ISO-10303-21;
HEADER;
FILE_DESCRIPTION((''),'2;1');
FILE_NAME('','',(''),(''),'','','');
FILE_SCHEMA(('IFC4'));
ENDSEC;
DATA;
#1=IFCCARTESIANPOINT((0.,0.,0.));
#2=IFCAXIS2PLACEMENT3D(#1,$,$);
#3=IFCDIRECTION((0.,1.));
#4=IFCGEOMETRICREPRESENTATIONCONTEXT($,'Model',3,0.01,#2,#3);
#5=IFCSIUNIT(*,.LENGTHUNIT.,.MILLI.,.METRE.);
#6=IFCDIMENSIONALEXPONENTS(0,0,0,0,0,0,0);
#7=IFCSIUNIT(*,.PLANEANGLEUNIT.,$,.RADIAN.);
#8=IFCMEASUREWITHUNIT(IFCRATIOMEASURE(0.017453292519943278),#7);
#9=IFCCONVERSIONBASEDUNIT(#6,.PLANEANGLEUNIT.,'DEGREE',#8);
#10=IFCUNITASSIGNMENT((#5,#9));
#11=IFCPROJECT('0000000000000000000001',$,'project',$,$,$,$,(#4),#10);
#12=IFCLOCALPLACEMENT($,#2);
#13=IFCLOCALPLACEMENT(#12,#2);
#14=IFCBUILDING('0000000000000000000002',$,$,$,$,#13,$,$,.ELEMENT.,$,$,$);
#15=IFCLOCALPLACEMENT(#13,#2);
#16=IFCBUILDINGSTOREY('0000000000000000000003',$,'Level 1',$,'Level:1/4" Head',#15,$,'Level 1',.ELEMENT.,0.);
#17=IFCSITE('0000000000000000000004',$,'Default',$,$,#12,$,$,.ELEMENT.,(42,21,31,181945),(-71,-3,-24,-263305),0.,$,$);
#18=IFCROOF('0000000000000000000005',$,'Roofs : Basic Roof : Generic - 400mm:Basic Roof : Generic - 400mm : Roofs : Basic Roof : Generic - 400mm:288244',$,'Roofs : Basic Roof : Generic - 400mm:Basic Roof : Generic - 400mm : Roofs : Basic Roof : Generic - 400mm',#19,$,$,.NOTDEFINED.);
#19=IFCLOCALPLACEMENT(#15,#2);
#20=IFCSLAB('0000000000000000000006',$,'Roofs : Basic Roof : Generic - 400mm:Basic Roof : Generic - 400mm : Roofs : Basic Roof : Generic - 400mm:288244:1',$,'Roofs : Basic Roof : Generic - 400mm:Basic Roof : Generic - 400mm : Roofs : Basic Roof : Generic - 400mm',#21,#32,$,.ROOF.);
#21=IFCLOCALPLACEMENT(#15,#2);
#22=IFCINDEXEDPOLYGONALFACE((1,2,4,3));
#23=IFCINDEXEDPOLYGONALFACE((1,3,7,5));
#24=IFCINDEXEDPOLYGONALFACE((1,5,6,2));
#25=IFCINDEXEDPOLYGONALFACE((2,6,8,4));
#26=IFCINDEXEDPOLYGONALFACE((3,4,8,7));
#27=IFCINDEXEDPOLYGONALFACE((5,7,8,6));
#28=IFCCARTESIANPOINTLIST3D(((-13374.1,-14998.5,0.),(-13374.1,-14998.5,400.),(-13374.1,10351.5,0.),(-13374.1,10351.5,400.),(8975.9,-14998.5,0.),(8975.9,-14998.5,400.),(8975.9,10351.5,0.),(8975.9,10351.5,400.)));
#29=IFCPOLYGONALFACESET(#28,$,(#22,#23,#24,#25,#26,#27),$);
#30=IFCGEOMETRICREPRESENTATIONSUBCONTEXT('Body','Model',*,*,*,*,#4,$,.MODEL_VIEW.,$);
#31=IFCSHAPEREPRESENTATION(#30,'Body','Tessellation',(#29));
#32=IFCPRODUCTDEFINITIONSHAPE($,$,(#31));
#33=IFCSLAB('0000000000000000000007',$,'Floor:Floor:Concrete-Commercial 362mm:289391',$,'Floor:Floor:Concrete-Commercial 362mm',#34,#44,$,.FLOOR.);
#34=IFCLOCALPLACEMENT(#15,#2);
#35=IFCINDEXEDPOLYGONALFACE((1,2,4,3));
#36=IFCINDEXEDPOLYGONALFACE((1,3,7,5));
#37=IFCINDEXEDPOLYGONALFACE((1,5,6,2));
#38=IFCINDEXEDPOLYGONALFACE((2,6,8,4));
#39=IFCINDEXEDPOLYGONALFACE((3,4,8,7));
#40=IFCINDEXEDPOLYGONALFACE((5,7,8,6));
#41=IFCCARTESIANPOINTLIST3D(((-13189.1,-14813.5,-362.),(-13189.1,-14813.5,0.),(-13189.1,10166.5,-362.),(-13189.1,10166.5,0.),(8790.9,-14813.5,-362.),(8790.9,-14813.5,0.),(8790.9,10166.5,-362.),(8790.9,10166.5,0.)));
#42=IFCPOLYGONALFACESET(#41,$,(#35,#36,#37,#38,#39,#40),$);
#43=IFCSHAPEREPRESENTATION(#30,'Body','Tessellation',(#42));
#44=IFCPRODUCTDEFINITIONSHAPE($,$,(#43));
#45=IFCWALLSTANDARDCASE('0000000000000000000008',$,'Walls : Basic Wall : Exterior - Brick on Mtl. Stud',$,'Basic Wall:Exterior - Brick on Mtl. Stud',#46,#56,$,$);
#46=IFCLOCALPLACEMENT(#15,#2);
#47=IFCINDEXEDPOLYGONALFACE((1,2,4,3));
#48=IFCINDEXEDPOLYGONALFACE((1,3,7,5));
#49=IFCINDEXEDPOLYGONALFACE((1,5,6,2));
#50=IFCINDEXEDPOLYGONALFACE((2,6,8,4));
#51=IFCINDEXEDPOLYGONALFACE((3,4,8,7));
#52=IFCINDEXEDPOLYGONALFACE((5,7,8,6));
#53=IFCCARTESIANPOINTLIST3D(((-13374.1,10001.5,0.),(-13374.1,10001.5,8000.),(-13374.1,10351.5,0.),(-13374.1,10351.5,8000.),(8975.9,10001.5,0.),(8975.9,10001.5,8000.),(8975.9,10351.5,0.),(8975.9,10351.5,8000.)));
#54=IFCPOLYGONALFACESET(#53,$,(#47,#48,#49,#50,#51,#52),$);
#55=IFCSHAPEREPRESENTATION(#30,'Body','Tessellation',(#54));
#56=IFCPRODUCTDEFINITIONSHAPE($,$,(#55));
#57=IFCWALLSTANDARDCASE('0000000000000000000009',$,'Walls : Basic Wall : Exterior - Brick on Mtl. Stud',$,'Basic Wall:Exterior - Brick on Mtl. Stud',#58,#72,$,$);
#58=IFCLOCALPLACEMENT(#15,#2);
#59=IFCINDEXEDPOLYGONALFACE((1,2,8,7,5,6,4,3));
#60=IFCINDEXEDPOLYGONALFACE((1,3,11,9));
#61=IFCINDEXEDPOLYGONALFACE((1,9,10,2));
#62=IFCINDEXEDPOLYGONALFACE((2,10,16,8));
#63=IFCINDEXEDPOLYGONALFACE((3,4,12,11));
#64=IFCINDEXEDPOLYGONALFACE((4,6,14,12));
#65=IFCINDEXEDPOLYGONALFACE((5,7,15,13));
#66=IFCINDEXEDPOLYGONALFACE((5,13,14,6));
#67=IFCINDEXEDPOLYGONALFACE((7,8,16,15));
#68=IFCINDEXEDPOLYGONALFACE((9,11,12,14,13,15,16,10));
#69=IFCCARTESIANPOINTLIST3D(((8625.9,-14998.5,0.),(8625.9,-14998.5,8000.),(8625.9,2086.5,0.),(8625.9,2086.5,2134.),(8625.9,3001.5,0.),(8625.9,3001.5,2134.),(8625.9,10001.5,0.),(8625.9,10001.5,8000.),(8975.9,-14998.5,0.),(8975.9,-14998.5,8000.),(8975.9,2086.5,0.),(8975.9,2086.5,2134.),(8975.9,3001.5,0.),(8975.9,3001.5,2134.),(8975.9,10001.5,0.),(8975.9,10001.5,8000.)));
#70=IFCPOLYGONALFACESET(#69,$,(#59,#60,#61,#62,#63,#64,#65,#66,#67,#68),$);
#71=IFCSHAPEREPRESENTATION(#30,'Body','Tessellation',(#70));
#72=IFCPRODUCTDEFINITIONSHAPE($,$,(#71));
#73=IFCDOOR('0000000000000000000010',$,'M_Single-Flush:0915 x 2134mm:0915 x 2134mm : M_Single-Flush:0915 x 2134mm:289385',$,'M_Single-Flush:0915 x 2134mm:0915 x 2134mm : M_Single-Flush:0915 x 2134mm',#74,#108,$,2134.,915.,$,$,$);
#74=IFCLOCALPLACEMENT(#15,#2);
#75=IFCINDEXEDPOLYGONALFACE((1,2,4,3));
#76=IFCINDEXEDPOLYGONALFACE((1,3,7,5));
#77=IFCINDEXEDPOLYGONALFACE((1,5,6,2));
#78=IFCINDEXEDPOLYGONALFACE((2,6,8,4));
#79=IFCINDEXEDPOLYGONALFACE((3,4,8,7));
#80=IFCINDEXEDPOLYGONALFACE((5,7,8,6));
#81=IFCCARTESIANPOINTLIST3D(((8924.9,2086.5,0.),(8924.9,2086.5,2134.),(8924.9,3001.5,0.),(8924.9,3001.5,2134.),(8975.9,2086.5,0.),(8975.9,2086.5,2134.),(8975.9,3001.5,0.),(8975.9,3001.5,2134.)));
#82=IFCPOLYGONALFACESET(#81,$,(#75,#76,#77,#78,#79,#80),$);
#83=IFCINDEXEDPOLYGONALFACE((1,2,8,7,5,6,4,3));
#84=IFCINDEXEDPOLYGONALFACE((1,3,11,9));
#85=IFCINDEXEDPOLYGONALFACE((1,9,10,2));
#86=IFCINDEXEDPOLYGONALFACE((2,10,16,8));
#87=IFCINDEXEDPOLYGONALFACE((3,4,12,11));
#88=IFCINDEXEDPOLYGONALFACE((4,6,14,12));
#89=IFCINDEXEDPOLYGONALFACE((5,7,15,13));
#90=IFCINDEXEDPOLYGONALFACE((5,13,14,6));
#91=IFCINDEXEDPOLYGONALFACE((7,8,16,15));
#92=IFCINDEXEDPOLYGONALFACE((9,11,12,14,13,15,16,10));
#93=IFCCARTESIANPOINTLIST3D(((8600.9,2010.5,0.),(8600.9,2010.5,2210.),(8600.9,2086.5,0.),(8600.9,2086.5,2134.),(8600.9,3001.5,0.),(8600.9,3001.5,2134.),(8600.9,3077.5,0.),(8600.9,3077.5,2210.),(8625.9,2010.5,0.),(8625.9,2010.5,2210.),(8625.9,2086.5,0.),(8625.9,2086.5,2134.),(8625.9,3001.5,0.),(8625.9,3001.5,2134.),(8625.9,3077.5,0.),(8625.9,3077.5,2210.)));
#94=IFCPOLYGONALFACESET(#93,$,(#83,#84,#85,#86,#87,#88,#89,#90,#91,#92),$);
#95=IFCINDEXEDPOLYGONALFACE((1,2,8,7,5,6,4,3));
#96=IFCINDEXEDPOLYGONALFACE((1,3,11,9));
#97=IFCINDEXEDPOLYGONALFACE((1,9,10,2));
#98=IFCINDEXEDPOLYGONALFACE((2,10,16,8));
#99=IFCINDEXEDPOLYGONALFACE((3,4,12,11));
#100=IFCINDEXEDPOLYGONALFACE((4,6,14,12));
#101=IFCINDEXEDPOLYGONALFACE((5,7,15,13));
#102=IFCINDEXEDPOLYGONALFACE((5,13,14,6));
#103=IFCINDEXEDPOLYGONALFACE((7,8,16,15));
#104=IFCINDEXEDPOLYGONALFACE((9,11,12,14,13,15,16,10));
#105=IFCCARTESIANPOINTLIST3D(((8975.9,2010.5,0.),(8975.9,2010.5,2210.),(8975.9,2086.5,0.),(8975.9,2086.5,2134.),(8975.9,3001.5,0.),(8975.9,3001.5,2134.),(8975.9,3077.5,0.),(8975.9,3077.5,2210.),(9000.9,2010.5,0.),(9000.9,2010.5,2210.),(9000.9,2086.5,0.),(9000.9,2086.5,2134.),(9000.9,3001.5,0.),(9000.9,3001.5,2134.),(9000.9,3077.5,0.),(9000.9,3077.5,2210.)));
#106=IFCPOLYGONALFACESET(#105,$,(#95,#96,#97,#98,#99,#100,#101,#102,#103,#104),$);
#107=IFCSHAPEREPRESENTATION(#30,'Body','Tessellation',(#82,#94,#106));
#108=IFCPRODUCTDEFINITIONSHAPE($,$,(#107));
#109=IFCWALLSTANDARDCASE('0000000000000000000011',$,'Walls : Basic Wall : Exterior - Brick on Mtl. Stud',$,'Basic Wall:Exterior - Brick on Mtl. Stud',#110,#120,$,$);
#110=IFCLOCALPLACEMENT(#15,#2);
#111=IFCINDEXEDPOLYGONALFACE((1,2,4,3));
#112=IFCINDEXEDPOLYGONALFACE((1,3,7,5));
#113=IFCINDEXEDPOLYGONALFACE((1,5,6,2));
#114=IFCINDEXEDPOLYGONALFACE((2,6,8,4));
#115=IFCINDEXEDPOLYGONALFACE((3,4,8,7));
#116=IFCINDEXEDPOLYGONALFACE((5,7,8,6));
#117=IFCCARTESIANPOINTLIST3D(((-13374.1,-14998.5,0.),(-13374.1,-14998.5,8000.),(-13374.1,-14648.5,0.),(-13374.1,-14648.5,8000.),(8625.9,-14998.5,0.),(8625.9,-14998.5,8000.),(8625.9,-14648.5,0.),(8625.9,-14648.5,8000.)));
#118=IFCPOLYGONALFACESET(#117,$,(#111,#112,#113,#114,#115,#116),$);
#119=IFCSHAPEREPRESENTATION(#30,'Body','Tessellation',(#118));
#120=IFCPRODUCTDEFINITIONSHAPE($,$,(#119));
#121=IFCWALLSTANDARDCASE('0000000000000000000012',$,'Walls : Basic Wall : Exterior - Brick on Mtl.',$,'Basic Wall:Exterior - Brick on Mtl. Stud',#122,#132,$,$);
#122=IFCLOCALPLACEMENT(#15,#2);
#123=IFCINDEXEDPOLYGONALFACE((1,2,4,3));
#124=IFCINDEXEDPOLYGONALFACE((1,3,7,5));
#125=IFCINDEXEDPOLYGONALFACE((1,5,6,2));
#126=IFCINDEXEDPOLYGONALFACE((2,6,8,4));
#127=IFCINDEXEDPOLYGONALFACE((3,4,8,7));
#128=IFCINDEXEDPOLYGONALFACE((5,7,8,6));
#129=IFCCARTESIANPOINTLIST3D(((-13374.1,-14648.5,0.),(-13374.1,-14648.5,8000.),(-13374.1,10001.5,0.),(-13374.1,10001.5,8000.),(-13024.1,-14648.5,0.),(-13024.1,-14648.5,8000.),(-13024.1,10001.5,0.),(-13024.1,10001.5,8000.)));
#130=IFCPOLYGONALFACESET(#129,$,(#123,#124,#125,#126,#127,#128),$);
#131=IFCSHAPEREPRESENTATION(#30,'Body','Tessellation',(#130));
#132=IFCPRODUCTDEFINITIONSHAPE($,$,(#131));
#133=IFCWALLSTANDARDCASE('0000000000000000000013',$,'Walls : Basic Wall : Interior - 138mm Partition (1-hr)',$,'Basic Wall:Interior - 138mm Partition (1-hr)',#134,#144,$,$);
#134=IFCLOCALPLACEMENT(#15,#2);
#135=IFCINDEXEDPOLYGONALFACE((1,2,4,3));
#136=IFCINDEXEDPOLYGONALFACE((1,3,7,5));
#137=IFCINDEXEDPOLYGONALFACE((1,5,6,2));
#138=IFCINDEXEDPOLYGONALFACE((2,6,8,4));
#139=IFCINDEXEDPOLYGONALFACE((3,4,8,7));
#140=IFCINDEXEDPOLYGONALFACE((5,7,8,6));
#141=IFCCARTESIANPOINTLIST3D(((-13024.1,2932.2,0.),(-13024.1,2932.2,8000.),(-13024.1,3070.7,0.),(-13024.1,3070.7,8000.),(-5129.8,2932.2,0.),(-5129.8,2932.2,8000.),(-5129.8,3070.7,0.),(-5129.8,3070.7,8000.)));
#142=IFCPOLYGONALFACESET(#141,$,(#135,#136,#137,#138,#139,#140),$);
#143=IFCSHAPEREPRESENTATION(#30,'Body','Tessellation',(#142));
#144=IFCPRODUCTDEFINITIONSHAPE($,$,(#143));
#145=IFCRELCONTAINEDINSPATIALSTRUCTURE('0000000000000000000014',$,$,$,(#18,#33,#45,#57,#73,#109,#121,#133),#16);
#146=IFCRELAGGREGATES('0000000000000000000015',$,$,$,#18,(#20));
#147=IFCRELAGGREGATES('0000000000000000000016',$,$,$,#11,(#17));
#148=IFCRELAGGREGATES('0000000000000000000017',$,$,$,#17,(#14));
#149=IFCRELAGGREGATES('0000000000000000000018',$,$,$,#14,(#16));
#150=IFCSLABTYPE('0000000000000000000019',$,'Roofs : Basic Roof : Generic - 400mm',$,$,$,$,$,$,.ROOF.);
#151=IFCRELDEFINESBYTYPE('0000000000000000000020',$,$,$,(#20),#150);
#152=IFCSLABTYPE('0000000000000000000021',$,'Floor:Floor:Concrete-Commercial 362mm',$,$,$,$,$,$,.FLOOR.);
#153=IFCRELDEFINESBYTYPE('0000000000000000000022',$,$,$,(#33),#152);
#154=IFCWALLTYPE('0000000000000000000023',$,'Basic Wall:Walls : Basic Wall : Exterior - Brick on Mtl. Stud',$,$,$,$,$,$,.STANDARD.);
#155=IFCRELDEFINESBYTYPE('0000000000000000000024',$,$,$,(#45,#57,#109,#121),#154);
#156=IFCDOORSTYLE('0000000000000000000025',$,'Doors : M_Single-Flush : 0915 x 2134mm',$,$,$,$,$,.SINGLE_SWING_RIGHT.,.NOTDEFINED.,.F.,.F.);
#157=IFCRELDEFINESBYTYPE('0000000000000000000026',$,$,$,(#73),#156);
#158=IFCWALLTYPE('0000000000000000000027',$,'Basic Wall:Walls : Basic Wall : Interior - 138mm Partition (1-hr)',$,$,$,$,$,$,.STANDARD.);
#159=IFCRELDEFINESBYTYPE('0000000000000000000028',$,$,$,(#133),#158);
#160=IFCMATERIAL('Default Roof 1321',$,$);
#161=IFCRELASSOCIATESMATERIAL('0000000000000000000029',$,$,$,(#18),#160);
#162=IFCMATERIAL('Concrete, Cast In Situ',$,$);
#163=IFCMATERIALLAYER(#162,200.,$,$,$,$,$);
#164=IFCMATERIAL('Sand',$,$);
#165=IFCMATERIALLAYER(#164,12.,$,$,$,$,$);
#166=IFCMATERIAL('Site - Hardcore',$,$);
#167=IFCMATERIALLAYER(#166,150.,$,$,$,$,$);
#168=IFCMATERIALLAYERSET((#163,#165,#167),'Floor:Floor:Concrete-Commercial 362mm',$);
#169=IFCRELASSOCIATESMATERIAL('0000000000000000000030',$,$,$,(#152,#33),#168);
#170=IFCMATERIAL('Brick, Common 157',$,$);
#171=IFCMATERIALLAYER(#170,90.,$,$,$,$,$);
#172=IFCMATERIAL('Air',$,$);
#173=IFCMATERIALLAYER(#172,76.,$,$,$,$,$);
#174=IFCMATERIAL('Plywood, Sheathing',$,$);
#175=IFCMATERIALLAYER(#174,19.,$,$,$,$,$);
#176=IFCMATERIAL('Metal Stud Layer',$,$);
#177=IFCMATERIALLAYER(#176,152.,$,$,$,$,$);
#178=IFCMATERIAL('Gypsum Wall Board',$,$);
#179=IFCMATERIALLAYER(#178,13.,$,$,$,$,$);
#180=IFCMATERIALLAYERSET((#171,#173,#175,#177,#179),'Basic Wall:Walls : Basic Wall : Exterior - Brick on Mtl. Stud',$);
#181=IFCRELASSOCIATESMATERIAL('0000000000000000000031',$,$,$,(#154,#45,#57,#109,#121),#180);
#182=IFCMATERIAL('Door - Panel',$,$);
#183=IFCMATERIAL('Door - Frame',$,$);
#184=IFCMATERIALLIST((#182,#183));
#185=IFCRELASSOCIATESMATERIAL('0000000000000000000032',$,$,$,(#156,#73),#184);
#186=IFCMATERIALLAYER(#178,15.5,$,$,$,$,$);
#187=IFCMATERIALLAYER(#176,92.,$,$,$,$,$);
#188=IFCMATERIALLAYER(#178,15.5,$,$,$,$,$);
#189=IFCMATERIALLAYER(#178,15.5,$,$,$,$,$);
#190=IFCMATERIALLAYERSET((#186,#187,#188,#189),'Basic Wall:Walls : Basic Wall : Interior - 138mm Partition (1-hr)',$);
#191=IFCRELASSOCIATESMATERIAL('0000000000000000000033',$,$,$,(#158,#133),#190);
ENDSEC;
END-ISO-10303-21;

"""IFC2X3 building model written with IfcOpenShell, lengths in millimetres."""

from ifc_helpers import new_model, entity, si_unit, converted_unit, direction, frame, frame_2d, origin, origin_2d_with_axis, place, context, subcontext, project, spatial, polyline, rectangle, outline, extrude, source, transform, mapped, material, material_list, layer, layer_set, layer_usage, type_object, type_shapes, element, fill, aggregate, save


model = new_model("IFC2X3")

# Units and contexts
model_context = context("Model", 3, precision=0.01, world=origin(), true_north=direction((0.0, 1.0)))
body_context = subcontext(model_context, "Body", "Model", "MODEL_VIEW")
ifc_project = project(units=[si_unit("LENGTHUNIT", "METRE", prefix="MILLI"), converted_unit("PLANEANGLEUNIT", "DEGREE", entity("IfcRatioMeasure", 0.017453292519943278), si_unit("PLANEANGLEUNIT", "RADIAN"), dimensions=[0, 0, 0, 0, 0, 0, 0])], contexts=[model_context])

# Site, building, storey
site_placement = place(None, origin())
site = spatial("IfcSite", under=ifc_project, at=site_placement, Name="Default", CompositionType="ELEMENT", RefLatitude=(42, 21, 31, 181945), RefLongitude=(-71, -3, -24, -263305), RefElevation=0.0)
building_placement = place(site_placement, origin())
building = spatial("IfcBuilding", under=site, at=building_placement, CompositionType="ELEMENT")
storey_placement = place(building_placement, origin())
storey = spatial("IfcBuildingStorey", under=building, at=storey_placement, Name="Level 1", ObjectType="Level:1/4\" Head", LongName="Level 1", CompositionType="ELEMENT", Elevation=0.0)

# Roof, slab
ifc_material_1 = material(Name="Default Roof 1321")
roof_placement = place(storey_placement, origin())
roof = element("IfcRoof", 1, at=roof_placement, inside=storey, material=ifc_material_1, Name="Roofs : Basic Roof : Generic - 400mm:Basic Roof : Generic - 400mm : Roofs : Basic Roof : Generic - 400mm:288244", ObjectType="Roofs : Basic Roof : Generic - 400mm:Basic Roof : Generic - 400mm : Roofs : Basic Roof : Generic - 400mm", ShapeType="NOTDEFINED")
slab_type_1 = type_object("IfcSlabType", Name="Roofs : Basic Roof : Generic - 400mm", PredefinedType="ROOF")
slab_1_placement = place(storey_placement, origin())
slab_1 = element("IfcSlab", 2, at=slab_1_placement, type_object=slab_type_1, Name="Roofs : Basic Roof : Generic - 400mm:Basic Roof : Generic - 400mm : Roofs : Basic Roof : Generic - 400mm:288244:1", ObjectType="Roofs : Basic Roof : Generic - 400mm:Basic Roof : Generic - 400mm : Roofs : Basic Roof : Generic - 400mm", PredefinedType="ROOF", context=body_context, shape_type="SweptSolid", body=[
    extrude(rectangle(XDim=22350.0, YDim=25350.0, at=origin_2d_with_axis()), frame((-2199.1, -2323.5, 0.0), z_axis=(0.0, 0.0, 1.0), x_axis=(-1.0, 0.0, 0.0)), (0.0, 0.0, 1.0), 400.0),
])
aggregate(roof, [slab_1])

# Slab
ifc_material_2 = material(Name="Concrete, Cast In Situ")
ifc_layer_1 = layer(ifc_material_2, 200.0)
ifc_material_3 = material(Name="Sand")
ifc_layer_2 = layer(ifc_material_3, 12.0)
ifc_material_4 = material(Name="Site - Hardcore")
ifc_layer_3 = layer(ifc_material_4, 150.0)
ifc_layer_set_1 = layer_set([ifc_layer_1, ifc_layer_2, ifc_layer_3], Name="Floor:Floor:Concrete-Commercial 362mm")
ifc_layer_usage_1 = layer_usage(ifc_layer_set_1, "AXIS3", "POSITIVE", 0.0)
slab_type_2 = type_object("IfcSlabType", Name="Floor:Floor:Concrete-Commercial 362mm", PredefinedType="FLOOR", material=ifc_layer_set_1)
slab_2_placement = place(storey_placement, origin())
element("IfcSlab", 3, at=slab_2_placement, inside=storey, type_object=slab_type_2, material=ifc_layer_usage_1, Name="Floor:Floor:Concrete-Commercial 362mm:289391", ObjectType="Floor:Floor:Concrete-Commercial 362mm", PredefinedType="FLOOR", context=body_context, shape_type="SweptSolid", body=[
    extrude(rectangle(XDim=24980.0, YDim=21980.0, at=origin_2d_with_axis()), frame((-2199.1, -2323.5, 0.0), z_axis=(0.0, 0.0, -1.0), x_axis=(0.0, 1.0, 0.0)), (0.0, 0.0, 1.0), 362.0),
])

# Wall
ifc_material_5 = material(Name="Brick, Common 157")
ifc_layer_4 = layer(ifc_material_5, 90.0)
ifc_material_6 = material(Name="Air")
ifc_layer_5 = layer(ifc_material_6, 76.0)
ifc_material_7 = material(Name="Plywood, Sheathing")
ifc_layer_6 = layer(ifc_material_7, 19.0)
ifc_material_8 = material(Name="Metal Stud Layer")
ifc_layer_7 = layer(ifc_material_8, 152.0)
ifc_material_9 = material(Name="Gypsum Wall Board")
ifc_layer_8 = layer(ifc_material_9, 13.0)
ifc_layer_set_2 = layer_set([ifc_layer_4, ifc_layer_5, ifc_layer_6, ifc_layer_7, ifc_layer_8], Name="Basic Wall:Walls : Basic Wall : Exterior - Brick on Mtl. Stud")
ifc_layer_usage_2 = layer_usage(ifc_layer_set_2, "AXIS2", "NEGATIVE", 175.0)
wall_type_1 = type_object("IfcWallType", Name="Basic Wall:Walls : Basic Wall : Exterior - Brick on Mtl. Stud", PredefinedType="STANDARD", material=ifc_layer_set_2)
wall_1_placement = place(storey_placement, frame((-13374.1, 10176.5, 0.0)))
element("IfcWallStandardCase", 4, at=wall_1_placement, inside=storey, type_object=wall_type_1, material=ifc_layer_usage_2, Name="Walls : Basic Wall : Exterior - Brick on Mtl. Stud", ObjectType="Basic Wall:Exterior - Brick on Mtl. Stud", context=body_context, shape_type="SweptSolid", body=[
    extrude(rectangle(XDim=22350.0, YDim=350.0, at=frame_2d((11175.0, 0.0), x_axis=(-1.0, 0.0))), origin(), (0.0, 0.0, 1.0), 8000.0),
])

# Wall, opening, door
wall_2_placement = place(storey_placement, frame((8800.9, 10001.5, 0.0), z_axis=(0.0, 0.0, 1.0), x_axis=(0.0, -1.0, 0.0)))
wall_2 = element("IfcWallStandardCase", 5, at=wall_2_placement, inside=storey, type_object=wall_type_1, material=ifc_layer_usage_2, Name="Walls : Basic Wall : Exterior - Brick on Mtl. Stud", ObjectType="Basic Wall:Exterior - Brick on Mtl. Stud", context=body_context, shape_type="SweptSolid", body=[
    extrude(rectangle(XDim=25000.0, YDim=350.0, at=frame_2d((12500.0, 0.0), x_axis=(1.0, 0.0))), origin(), (0.0, 0.0, 1.0), 8000.0),
])
opening_1_placement = place(wall_2_placement, frame((7915.0, -178.5, 0.0), z_axis=(0.0, 0.0, 1.0), x_axis=(0.0, 1.0, 0.0)))
opening_1 = element("IfcOpeningElement", 6, at=opening_1_placement, cuts=wall_2, ObjectType="Opening", context=body_context, shape_type="SweptSolid", body=[
    extrude(rectangle(XDim=2134.0, YDim=915.0, at=origin_2d_with_axis()), frame((0.0, 457.5, 1067.0), z_axis=(1.0, 0.0, 0.0), x_axis=(0.0, 0.0, -1.0)), (0.0, 0.0, 1.0), 357.0),
])
ifc_material_10 = material(Name="Door - Panel")
ifc_material_11 = material(Name="Door - Frame")
ifc_material_list = material_list([ifc_material_10, ifc_material_11])
door_style_1 = type_object("IfcDoorStyle", Name="Doors : M_Single-Flush : 0915 x 2134mm", ConstructionType="NOTDEFINED", OperationType="SINGLE_SWING_RIGHT", ParameterTakesPrecedence=False, Sizeable=False, material=ifc_material_list)
shared_shape_1 = source(origin(), body_context, "Body", "SweptSolid", [
    extrude(rectangle(XDim=915.0, YDim=51.0, at=frame_2d((0.0, 0.0), x_axis=(1.0, 0.0))), frame((457.5, -29.0, 0.0), z_axis=(0.0, 0.0, 1.0), x_axis=(-1.0, 0.0, 0.0)), (0.0, 0.0, 1.0), 2134.0),
    extrude(outline(polyline([(-533.5, -1086.0), (-457.5, -1086.0), (-457.5, 1048.0), (457.5, 1048.0), (457.5, -1086.0), (533.5, -1086.0), (533.5, 1124.0), (-533.5, 1124.0), (-533.5, -1086.0)])), frame((457.5, -378.5, 1086.0), z_axis=(0.0, 1.0, 0.0), x_axis=(-1.0, 0.0, 0.0)), (0.0, 0.0, 1.0), 25.0),
    extrude(outline(polyline([(-1124.0, -533.5), (1086.0, -533.5), (1086.0, -457.5), (-1048.0, -457.5), (-1048.0, 457.5), (1086.0, 457.5), (1086.0, 533.5), (-1124.0, 533.5), (-1124.0, -533.5)])), frame((457.5, -3.5, 1086.0), z_axis=(0.0, 1.0, 0.0), x_axis=(0.0, 0.0, -1.0)), (0.0, 0.0, 1.0), 25.0),
])
type_shapes(door_style_1, [shared_shape_1])
door_1_placement = place(opening_1_placement, frame((357.0, 915.0, 0.0), z_axis=(0.0, 0.0, 1.0), x_axis=(0.0, -1.0, 0.0)))
door_1 = element("IfcDoor", 7, at=door_1_placement, inside=storey, type_object=door_style_1, material=ifc_material_list, Name="M_Single-Flush:0915 x 2134mm:0915 x 2134mm : M_Single-Flush:0915 x 2134mm:289385", ObjectType="M_Single-Flush:0915 x 2134mm:0915 x 2134mm : M_Single-Flush:0915 x 2134mm", OverallHeight=2134.0, OverallWidth=915.0, context=body_context, shape_type="MappedRepresentation", body=[
    mapped(shared_shape_1, transform((0.0, 0.0, 0.0), scale=1.0)),
])
fill(opening_1, door_1)

# Walls
wall_3_placement = place(storey_placement, frame((8625.9, -14823.5, 0.0), z_axis=(0.0, 0.0, 1.0), x_axis=(-1.0, 0.0, 0.0)))
element("IfcWallStandardCase", 8, at=wall_3_placement, inside=storey, type_object=wall_type_1, material=ifc_layer_usage_2, Name="Walls : Basic Wall : Exterior - Brick on Mtl. Stud", ObjectType="Basic Wall:Exterior - Brick on Mtl. Stud", context=body_context, shape_type="SweptSolid", body=[
    extrude(rectangle(XDim=22000.0, YDim=350.0, at=frame_2d((11000.0, 0.0), x_axis=(-1.0, 0.0))), origin(), (0.0, 0.0, 1.0), 8000.0),
])
wall_4_placement = place(storey_placement, frame((-13199.1, -14648.5, 0.0), z_axis=(0.0, 0.0, 1.0), x_axis=(0.0, 1.0, 0.0)))
element("IfcWallStandardCase", 9, at=wall_4_placement, inside=storey, type_object=wall_type_1, material=ifc_layer_usage_2, Name="Walls : Basic Wall : Exterior - Brick on Mtl.", ObjectType="Basic Wall:Exterior - Brick on Mtl. Stud", context=body_context, shape_type="SweptSolid", body=[
    extrude(rectangle(XDim=24650.0, YDim=350.0, at=frame_2d((12325.0, 0.0), x_axis=(-1.0, 0.0))), origin(), (0.0, 0.0, 1.0), 8000.0),
])
ifc_layer_9 = layer(ifc_material_9, 15.5)
ifc_layer_10 = layer(ifc_material_8, 92.0)
ifc_layer_11 = layer(ifc_material_9, 15.5)
ifc_layer_12 = layer(ifc_material_9, 15.5)
ifc_layer_set_3 = layer_set([ifc_layer_9, ifc_layer_10, ifc_layer_11, ifc_layer_12], Name="Basic Wall:Walls : Basic Wall : Interior - 138mm Partition (1-hr)")
ifc_layer_usage_3 = layer_usage(ifc_layer_set_3, "AXIS2", "NEGATIVE", 69.2)
wall_type_2 = type_object("IfcWallType", Name="Basic Wall:Walls : Basic Wall : Interior - 138mm Partition (1-hr)", PredefinedType="STANDARD", material=ifc_layer_set_3)
wall_5_placement = place(storey_placement, frame((-13024.1, 3001.5, 0.0)))
element("IfcWallStandardCase", 10, at=wall_5_placement, inside=storey, type_object=wall_type_2, material=ifc_layer_usage_3, Name="Walls : Basic Wall : Interior - 138mm Partition (1-hr)", ObjectType="Basic Wall:Interior - 138mm Partition (1-hr)", context=body_context, shape_type="SweptSolid", body=[
    extrude(rectangle(XDim=7894.3, YDim=138.5, at=frame_2d((3947.1, 0.0), x_axis=(-1.0, 0.0))), origin(), (0.0, 0.0, 1.0), 8000.0),
])

save(model, "model.ifc")
